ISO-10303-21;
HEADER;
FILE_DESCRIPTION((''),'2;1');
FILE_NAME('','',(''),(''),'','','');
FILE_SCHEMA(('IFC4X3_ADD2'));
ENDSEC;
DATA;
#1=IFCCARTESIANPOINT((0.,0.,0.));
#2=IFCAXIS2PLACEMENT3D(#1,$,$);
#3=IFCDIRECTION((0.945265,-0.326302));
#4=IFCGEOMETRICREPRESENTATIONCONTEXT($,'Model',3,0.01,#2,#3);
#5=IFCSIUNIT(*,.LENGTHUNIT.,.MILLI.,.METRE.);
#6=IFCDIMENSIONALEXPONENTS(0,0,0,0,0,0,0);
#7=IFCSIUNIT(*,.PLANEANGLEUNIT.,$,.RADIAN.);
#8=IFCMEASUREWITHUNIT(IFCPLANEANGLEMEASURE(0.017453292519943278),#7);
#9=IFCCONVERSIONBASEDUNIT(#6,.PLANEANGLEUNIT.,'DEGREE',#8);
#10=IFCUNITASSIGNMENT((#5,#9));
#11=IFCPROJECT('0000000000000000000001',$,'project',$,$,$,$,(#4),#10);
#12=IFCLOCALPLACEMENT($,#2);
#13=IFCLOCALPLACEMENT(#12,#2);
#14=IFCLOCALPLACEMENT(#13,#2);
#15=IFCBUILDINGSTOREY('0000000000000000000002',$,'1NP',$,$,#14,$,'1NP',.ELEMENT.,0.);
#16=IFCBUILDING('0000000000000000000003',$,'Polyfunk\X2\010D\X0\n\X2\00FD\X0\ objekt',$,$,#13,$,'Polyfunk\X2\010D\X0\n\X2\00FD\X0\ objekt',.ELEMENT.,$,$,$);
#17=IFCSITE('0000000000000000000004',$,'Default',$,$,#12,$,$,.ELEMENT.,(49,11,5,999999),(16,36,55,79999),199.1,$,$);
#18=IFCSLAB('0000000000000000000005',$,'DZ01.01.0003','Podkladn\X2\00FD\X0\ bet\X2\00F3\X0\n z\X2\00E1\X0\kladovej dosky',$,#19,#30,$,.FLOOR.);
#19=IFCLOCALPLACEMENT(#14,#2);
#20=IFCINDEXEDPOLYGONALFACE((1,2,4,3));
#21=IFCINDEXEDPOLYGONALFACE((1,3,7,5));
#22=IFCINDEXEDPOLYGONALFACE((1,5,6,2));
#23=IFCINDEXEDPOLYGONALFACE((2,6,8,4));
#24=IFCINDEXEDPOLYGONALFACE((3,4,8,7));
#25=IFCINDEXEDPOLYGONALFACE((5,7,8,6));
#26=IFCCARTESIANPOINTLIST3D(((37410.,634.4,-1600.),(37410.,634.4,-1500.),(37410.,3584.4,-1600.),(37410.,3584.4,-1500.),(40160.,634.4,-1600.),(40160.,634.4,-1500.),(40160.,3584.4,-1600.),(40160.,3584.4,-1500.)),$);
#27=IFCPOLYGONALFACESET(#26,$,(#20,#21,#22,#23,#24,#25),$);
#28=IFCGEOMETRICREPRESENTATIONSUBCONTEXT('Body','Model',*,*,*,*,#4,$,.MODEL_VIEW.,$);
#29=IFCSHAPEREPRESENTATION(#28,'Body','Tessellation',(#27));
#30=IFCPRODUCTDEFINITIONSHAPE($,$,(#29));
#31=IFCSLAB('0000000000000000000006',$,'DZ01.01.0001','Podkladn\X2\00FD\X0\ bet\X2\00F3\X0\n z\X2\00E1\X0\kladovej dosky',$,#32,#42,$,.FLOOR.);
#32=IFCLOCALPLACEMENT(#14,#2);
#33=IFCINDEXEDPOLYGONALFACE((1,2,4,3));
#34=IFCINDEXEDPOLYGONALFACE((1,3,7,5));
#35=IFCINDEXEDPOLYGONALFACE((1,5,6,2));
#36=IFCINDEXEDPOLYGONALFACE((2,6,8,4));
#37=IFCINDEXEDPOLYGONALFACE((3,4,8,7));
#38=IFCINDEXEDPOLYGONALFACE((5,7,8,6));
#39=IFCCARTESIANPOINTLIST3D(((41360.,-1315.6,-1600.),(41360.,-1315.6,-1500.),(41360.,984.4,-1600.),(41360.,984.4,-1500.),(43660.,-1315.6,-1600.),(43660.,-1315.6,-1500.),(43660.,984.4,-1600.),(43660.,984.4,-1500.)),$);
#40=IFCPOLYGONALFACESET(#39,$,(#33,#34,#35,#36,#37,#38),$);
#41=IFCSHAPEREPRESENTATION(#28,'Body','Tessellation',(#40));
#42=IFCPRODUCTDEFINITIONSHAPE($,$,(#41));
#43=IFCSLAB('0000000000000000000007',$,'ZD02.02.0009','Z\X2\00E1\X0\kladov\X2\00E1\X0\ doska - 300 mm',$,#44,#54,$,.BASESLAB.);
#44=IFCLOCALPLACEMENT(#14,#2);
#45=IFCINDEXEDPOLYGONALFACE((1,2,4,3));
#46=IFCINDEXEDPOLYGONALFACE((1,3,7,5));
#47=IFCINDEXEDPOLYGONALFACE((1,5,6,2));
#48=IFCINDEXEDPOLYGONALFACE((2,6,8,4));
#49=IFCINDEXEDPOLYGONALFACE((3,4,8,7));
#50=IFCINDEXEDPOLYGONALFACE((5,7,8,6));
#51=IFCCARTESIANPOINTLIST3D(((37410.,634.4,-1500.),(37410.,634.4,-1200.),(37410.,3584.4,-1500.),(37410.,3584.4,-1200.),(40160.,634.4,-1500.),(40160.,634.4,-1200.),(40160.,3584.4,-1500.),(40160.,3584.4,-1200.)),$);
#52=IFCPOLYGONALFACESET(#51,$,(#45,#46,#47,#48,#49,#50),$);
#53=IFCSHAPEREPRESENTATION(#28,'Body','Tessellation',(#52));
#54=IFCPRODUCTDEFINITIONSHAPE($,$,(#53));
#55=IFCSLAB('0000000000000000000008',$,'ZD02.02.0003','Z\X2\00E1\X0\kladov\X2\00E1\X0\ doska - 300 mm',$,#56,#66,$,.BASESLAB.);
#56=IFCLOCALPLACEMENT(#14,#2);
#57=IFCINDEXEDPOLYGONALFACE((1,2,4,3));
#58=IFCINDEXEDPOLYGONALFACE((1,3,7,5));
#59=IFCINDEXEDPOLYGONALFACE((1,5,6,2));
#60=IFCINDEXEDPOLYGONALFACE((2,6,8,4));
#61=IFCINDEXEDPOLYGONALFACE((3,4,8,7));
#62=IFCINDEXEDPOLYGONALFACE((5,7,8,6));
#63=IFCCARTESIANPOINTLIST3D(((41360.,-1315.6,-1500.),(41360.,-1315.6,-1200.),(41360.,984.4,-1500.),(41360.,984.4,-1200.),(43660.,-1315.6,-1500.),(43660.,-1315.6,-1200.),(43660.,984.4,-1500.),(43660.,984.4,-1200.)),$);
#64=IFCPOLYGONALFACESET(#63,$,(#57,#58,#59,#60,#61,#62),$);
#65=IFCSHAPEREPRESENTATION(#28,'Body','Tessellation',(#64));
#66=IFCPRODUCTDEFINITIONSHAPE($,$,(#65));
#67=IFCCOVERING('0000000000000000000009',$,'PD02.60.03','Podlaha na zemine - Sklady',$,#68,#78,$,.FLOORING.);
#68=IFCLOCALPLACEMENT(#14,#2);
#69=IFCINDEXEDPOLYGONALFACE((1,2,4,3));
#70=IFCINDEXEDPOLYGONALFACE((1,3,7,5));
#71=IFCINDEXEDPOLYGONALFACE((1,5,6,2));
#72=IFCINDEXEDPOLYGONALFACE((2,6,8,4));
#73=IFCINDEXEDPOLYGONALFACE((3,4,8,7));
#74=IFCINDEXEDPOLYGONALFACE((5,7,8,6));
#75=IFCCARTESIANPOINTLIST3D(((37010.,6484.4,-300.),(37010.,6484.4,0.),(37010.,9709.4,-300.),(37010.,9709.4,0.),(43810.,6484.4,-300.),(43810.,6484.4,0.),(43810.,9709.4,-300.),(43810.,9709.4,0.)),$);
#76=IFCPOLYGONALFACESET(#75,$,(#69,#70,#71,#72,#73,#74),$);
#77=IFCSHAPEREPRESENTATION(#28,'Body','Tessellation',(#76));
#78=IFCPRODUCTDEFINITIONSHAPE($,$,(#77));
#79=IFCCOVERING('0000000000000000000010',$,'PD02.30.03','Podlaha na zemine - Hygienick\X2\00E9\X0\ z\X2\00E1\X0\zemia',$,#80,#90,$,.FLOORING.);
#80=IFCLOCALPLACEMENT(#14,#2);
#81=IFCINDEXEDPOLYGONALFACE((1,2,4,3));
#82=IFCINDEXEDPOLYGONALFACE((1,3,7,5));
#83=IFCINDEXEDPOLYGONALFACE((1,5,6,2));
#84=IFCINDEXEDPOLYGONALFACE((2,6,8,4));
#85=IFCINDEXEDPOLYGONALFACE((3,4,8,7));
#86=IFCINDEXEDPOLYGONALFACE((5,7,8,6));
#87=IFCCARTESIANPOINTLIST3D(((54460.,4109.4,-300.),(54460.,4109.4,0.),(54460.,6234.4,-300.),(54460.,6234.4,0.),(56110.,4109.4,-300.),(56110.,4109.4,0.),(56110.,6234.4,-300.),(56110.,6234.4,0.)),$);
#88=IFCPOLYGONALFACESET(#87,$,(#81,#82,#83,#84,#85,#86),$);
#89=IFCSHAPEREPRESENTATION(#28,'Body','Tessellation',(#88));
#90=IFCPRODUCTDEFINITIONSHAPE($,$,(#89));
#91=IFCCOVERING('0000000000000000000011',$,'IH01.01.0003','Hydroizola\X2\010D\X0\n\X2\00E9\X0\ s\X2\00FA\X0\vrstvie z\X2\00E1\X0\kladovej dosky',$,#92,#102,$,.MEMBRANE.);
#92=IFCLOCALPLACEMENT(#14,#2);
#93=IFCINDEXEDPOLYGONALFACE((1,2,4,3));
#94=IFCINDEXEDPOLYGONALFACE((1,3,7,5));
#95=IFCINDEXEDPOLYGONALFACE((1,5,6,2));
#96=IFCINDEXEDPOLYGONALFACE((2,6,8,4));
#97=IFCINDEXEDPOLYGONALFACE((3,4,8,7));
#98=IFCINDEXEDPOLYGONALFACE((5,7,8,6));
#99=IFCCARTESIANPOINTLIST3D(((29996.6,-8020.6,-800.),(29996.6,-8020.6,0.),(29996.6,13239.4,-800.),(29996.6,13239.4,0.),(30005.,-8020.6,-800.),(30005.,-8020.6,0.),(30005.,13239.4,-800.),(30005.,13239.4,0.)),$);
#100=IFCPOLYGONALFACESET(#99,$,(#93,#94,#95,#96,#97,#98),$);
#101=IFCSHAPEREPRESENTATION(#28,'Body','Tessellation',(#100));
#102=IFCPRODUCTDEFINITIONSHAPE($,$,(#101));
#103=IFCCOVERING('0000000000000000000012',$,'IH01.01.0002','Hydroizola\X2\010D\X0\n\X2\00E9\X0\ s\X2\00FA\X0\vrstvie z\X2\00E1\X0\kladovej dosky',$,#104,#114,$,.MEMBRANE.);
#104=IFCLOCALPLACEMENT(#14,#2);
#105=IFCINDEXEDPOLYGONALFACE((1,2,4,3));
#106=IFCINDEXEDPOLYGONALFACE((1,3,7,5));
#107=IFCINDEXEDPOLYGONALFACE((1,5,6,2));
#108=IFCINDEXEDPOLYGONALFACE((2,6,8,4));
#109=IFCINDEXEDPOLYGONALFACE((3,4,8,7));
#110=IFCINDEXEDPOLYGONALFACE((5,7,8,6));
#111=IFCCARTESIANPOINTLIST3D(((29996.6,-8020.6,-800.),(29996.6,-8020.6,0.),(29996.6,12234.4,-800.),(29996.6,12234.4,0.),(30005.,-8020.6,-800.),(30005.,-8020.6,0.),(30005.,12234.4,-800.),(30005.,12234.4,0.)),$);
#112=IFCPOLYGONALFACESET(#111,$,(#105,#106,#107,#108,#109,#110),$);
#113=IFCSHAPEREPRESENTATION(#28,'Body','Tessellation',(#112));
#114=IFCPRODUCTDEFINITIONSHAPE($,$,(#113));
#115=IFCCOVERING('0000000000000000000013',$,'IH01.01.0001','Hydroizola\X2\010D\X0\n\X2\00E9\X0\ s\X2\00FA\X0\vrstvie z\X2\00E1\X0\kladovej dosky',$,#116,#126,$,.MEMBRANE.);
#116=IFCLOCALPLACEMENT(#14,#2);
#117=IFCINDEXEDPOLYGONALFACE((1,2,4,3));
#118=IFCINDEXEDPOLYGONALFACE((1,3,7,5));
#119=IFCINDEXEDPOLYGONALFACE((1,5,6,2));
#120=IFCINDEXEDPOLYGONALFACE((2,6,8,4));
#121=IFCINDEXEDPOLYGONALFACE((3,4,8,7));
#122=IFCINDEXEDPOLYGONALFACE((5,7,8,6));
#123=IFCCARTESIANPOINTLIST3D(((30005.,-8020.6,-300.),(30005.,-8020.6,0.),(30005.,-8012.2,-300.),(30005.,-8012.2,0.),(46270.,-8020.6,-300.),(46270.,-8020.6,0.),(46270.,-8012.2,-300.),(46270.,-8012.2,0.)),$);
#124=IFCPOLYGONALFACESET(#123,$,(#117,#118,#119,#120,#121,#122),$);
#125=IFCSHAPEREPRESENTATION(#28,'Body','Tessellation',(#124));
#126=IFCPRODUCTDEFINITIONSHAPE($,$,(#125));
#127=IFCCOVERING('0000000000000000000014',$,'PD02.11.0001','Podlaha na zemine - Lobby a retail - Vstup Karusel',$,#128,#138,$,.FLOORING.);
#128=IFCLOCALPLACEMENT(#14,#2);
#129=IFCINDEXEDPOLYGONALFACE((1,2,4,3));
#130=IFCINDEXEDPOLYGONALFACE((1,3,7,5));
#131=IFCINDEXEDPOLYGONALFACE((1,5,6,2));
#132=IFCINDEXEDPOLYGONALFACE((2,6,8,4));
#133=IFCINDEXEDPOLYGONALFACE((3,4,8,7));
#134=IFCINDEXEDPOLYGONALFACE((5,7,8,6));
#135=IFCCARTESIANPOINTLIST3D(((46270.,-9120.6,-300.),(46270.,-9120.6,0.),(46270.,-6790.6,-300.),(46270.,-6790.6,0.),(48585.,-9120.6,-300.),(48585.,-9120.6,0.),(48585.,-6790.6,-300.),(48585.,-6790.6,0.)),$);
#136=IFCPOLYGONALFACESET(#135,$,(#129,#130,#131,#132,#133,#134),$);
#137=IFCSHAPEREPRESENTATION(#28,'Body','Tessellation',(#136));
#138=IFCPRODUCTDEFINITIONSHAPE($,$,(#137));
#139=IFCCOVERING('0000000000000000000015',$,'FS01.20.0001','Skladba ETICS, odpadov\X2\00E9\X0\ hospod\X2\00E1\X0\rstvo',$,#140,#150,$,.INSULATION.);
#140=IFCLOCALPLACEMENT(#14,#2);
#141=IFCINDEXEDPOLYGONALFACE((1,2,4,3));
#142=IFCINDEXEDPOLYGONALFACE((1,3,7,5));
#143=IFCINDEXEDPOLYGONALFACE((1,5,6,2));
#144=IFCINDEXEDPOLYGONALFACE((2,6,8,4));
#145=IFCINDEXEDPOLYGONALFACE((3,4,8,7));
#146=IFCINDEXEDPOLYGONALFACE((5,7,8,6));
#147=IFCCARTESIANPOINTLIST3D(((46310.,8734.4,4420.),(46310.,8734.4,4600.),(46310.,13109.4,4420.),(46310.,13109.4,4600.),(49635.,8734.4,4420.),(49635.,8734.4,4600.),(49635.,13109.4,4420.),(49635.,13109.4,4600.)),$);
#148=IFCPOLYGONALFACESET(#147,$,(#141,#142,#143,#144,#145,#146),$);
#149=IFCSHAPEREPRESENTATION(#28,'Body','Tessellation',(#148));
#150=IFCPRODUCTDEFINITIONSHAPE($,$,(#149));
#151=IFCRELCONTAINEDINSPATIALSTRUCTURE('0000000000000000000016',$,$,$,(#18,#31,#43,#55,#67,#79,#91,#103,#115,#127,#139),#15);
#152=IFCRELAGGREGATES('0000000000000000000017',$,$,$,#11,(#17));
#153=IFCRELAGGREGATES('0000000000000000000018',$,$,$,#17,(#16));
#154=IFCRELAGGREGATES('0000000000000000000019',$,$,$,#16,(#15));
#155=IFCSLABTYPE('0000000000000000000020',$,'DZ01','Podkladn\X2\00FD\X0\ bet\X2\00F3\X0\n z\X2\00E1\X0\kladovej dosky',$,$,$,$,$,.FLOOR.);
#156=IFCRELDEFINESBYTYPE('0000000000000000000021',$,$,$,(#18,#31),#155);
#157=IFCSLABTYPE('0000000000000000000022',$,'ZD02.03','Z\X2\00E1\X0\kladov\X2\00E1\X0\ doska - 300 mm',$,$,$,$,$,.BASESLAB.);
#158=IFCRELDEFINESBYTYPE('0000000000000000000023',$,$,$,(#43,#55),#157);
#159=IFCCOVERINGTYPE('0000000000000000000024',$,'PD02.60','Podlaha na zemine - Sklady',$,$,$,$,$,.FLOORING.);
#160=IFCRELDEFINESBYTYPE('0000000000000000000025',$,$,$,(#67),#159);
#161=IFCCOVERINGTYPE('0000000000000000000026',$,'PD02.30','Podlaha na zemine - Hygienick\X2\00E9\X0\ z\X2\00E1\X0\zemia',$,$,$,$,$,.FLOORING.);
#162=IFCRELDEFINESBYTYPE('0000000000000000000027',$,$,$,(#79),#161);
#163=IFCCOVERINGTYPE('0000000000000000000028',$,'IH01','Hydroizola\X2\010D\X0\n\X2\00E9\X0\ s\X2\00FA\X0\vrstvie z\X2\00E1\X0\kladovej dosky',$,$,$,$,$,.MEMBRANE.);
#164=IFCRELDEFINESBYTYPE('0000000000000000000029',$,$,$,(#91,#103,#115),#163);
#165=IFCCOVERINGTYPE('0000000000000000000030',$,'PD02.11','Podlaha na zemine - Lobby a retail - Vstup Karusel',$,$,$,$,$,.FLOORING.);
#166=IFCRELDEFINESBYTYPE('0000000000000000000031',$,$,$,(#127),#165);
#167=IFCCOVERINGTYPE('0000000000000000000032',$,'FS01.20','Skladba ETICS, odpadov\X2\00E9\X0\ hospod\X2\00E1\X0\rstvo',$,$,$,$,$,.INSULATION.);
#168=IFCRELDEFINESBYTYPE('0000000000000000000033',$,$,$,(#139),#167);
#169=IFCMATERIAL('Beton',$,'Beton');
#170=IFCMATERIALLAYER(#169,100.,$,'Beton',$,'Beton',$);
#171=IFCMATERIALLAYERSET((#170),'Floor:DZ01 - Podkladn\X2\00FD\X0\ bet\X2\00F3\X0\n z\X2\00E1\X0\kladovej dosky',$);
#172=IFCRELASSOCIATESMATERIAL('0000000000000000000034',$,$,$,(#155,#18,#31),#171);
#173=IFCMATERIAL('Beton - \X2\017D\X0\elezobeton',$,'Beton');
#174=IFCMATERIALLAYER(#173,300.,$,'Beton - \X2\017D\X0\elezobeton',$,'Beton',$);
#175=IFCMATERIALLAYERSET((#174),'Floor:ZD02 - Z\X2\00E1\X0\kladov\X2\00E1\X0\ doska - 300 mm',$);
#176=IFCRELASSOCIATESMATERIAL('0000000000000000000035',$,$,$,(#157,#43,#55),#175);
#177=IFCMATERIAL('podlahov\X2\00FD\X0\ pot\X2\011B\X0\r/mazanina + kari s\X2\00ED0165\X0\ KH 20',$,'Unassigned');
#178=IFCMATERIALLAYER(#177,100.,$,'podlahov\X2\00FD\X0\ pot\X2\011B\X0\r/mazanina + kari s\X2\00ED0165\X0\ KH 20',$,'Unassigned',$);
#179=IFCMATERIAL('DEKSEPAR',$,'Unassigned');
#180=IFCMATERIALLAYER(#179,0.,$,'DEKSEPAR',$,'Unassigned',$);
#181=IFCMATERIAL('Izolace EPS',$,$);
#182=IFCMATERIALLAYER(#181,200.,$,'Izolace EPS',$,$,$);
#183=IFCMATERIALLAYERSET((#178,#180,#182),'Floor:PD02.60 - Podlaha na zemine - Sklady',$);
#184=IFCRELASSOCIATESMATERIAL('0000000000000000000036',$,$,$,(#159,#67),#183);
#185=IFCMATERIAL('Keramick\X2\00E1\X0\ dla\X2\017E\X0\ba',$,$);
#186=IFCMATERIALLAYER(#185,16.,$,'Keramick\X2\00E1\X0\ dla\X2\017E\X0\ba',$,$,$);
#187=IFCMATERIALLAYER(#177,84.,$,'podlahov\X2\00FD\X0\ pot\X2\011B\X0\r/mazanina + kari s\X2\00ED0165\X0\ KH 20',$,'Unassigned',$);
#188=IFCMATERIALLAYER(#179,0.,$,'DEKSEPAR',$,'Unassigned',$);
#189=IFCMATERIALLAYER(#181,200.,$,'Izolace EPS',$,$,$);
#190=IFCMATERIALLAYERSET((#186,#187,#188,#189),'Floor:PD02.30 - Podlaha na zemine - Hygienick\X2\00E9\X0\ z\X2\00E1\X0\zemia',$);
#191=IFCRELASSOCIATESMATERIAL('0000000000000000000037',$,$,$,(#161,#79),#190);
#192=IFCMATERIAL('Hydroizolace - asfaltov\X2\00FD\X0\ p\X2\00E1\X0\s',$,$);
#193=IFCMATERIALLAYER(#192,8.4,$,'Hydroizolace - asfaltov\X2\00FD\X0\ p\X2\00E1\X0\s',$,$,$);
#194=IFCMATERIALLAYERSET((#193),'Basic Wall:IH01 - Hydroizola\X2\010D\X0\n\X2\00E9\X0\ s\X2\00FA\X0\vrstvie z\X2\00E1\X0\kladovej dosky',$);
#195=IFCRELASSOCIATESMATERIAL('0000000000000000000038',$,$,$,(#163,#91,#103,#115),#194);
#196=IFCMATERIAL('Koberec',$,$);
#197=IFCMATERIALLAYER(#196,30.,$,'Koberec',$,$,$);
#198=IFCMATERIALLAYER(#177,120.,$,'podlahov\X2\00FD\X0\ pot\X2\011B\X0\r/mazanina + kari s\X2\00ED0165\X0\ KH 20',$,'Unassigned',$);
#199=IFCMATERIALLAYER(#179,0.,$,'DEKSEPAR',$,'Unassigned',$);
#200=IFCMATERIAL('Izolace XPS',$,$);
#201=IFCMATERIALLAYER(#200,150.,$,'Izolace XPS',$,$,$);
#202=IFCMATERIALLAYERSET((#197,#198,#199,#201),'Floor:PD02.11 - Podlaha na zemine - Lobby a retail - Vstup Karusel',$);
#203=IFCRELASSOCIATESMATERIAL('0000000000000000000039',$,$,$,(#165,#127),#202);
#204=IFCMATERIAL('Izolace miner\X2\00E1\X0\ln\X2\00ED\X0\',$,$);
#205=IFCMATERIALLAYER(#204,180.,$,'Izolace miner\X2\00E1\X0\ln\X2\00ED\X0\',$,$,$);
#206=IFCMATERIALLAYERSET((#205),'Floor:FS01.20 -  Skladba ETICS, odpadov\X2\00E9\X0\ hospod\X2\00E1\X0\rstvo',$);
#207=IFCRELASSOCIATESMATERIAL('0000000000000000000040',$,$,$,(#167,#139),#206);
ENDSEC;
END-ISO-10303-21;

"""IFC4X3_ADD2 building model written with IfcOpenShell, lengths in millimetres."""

from ifc_helpers import new_model, entity, si_unit, converted_unit, direction, frame, frame_2d, origin, origin_2d_with_axis, place, context, subcontext, project, spatial, rectangle, extrude, material, layer, layer_set, layer_usage, type_object, element, save


model = new_model("IFC4X3_ADD2")

# Units and contexts
model_context = context("Model", 3, precision=0.01, world=origin(), true_north=direction((0.945265, -0.326302)))
body_context = subcontext(model_context, "Body", "Model", "MODEL_VIEW")
ifc_project = project(units=[si_unit("LENGTHUNIT", "METRE", prefix="MILLI"), converted_unit("PLANEANGLEUNIT", "DEGREE", entity("IfcPlaneAngleMeasure", 0.017453292519943278), si_unit("PLANEANGLEUNIT", "RADIAN"), dimensions=[0, 0, 0, 0, 0, 0, 0])], contexts=[model_context])

# Site, building, storey
site_placement = place(None, origin())
site = spatial("IfcSite", under=ifc_project, at=site_placement, Name="Default", CompositionType="ELEMENT", RefLatitude=(49, 11, 5, 999999), RefLongitude=(16, 36, 55, 79999), RefElevation=199.1)
building_placement = place(site_placement, origin())
building = spatial("IfcBuilding", under=site, at=building_placement, Name="Polyfunkčný objekt", LongName="Polyfunkčný objekt", CompositionType="ELEMENT")
storey_placement = place(building_placement, origin())
storey = spatial("IfcBuildingStorey", under=building, at=storey_placement, Name="1NP", LongName="1NP", CompositionType="ELEMENT", Elevation=0.0)

# Shared definitions
ifc_material_1 = material(Name="Beton", Category="Beton")
ifc_layer_1 = layer(ifc_material_1, 100.0, Name="Beton", Category="Beton")
ifc_layer_set_1 = layer_set([ifc_layer_1], Name="Floor:DZ01 - Podkladný betón základovej dosky")
slab_type_1 = type_object("IfcSlabType", Name="DZ01", Description="Podkladný betón základovej dosky", PredefinedType="FLOOR", material=ifc_layer_set_1)

# Slabs
ifc_layer_usage_1 = layer_usage(ifc_layer_set_1, "AXIS3", "POSITIVE", 0.0)
slab_1_placement = place(storey_placement, origin())
element("IfcSlab", 1, at=slab_1_placement, inside=storey, type_object=slab_type_1, material=ifc_layer_usage_1, Name="DZ01.01.0003", Description="Podkladný betón základovej dosky", PredefinedType="FLOOR", context=body_context, shape_type="SweptSolid", body=[
    extrude(rectangle(XDim=2950.0, YDim=2750.0, at=frame_2d((0.0, 0.0), x_axis=(1.0, 0.0))), frame((38785.0, 2109.4, -1500.0), z_axis=(0.0, 0.0, -1.0), x_axis=(0.0, 1.0, 0.0)), (0.0, 0.0, 1.0), 100.0),
])
ifc_layer_usage_2 = layer_usage(ifc_layer_set_1, "AXIS3", "POSITIVE", 0.0)
slab_2_placement = place(storey_placement, origin())
element("IfcSlab", 2, at=slab_2_placement, inside=storey, type_object=slab_type_1, material=ifc_layer_usage_2, Name="DZ01.01.0001", Description="Podkladný betón základovej dosky", PredefinedType="FLOOR", context=body_context, shape_type="SweptSolid", body=[
    extrude(rectangle(XDim=2300.0, YDim=2300.0, at=frame_2d((0.0, 0.0), x_axis=(1.0, 0.0))), frame((42510.0, -165.6, -1500.0), z_axis=(0.0, 0.0, -1.0), x_axis=(0.0, 1.0, 0.0)), (0.0, 0.0, 1.0), 100.0),
])
ifc_material_2 = material(Name="Beton - Železobeton", Category="Beton")
ifc_layer_2 = layer(ifc_material_2, 300.0, Name="Beton - Železobeton", Category="Beton")
ifc_layer_set_2 = layer_set([ifc_layer_2], Name="Floor:ZD02 - Základová doska - 300 mm")
ifc_layer_usage_3 = layer_usage(ifc_layer_set_2, "AXIS3", "POSITIVE", 0.0)
slab_type_2 = type_object("IfcSlabType", Name="ZD02.03", Description="Základová doska - 300 mm", PredefinedType="BASESLAB", material=ifc_layer_set_2)
slab_3_placement = place(storey_placement, origin())
element("IfcSlab", 3, at=slab_3_placement, inside=storey, type_object=slab_type_2, material=ifc_layer_usage_3, Name="ZD02.02.0009", Description="Základová doska - 300 mm", PredefinedType="BASESLAB", context=body_context, shape_type="SweptSolid", body=[
    extrude(rectangle(XDim=2950.0, YDim=2750.0, at=frame_2d((0.0, 0.0), x_axis=(1.0, 0.0))), frame((38785.0, 2109.4, -1200.0), z_axis=(0.0, 0.0, -1.0), x_axis=(0.0, 1.0, 0.0)), (0.0, 0.0, 1.0), 300.0),
])
ifc_layer_usage_4 = layer_usage(ifc_layer_set_2, "AXIS3", "POSITIVE", 0.0)
slab_4_placement = place(storey_placement, origin())
element("IfcSlab", 4, at=slab_4_placement, inside=storey, type_object=slab_type_2, material=ifc_layer_usage_4, Name="ZD02.02.0003", Description="Základová doska - 300 mm", PredefinedType="BASESLAB", context=body_context, shape_type="SweptSolid", body=[
    extrude(rectangle(XDim=2300.0, YDim=2300.0, at=frame_2d((0.0, 0.0), x_axis=(1.0, 0.0))), frame((42510.0, -165.6, -1200.0), z_axis=(0.0, 0.0, -1.0), x_axis=(0.0, 1.0, 0.0)), (0.0, 0.0, 1.0), 300.0),
])

# Coverings
ifc_material_3 = material(Name="podlahový potěr/mazanina + kari síť KH 20", Category="Unassigned")
ifc_layer_3 = layer(ifc_material_3, 100.0, Name="podlahový potěr/mazanina + kari síť KH 20", Category="Unassigned")
ifc_material_4 = material(Name="DEKSEPAR", Category="Unassigned")
ifc_layer_4 = layer(ifc_material_4, 0.0, Name="DEKSEPAR", Category="Unassigned")
ifc_material_5 = material(Name="Izolace EPS")
ifc_layer_5 = layer(ifc_material_5, 200.0, Name="Izolace EPS")
ifc_layer_set_3 = layer_set([ifc_layer_3, ifc_layer_4, ifc_layer_5], Name="Floor:PD02.60 - Podlaha na zemine - Sklady")
ifc_layer_usage_5 = layer_usage(ifc_layer_set_3, "AXIS3", "POSITIVE", 0.0)
covering_type_1 = type_object("IfcCoveringType", Name="PD02.60", Description="Podlaha na zemine - Sklady", PredefinedType="FLOORING", material=ifc_layer_set_3)
covering_1_placement = place(storey_placement, origin())
element("IfcCovering", 5, at=covering_1_placement, inside=storey, type_object=covering_type_1, material=ifc_layer_usage_5, Name="PD02.60.03", Description="Podlaha na zemine - Sklady", PredefinedType="FLOORING", context=body_context, shape_type="SweptSolid", body=[
    extrude(rectangle(XDim=3225.0, YDim=6800.0, at=origin_2d_with_axis()), frame((40410.0, 8096.9, 0.0), z_axis=(0.0, 0.0, -1.0), x_axis=(0.0, 1.0, 0.0)), (0.0, 0.0, 1.0), 300.0),
])
ifc_material_6 = material(Name="Keramická dlažba")
ifc_layer_6 = layer(ifc_material_6, 16.0, Name="Keramická dlažba")
ifc_layer_7 = layer(ifc_material_3, 84.0, Name="podlahový potěr/mazanina + kari síť KH 20", Category="Unassigned")
ifc_layer_8 = layer(ifc_material_4, 0.0, Name="DEKSEPAR", Category="Unassigned")
ifc_layer_9 = layer(ifc_material_5, 200.0, Name="Izolace EPS")
ifc_layer_set_4 = layer_set([ifc_layer_6, ifc_layer_7, ifc_layer_8, ifc_layer_9], Name="Floor:PD02.30 - Podlaha na zemine - Hygienické zázemia")
covering_type_2 = type_object("IfcCoveringType", Name="PD02.30", Description="Podlaha na zemine - Hygienické zázemia", PredefinedType="FLOORING", material=ifc_layer_set_4)
ifc_layer_usage_6 = layer_usage(ifc_layer_set_4, "AXIS3", "POSITIVE", 0.0)
covering_2_placement = place(storey_placement, origin())
element("IfcCovering", 6, at=covering_2_placement, inside=storey, type_object=covering_type_2, material=ifc_layer_usage_6, Name="PD02.30.03", Description="Podlaha na zemine - Hygienické zázemia", PredefinedType="FLOORING", context=body_context, shape_type="SweptSolid", body=[
    extrude(rectangle(XDim=2125.0, YDim=1650.0, at=frame_2d((0.0, 0.0), x_axis=(1.0, 0.0))), frame((55285.0, 5171.9, 0.0), z_axis=(0.0, 0.0, -1.0), x_axis=(0.0, 1.0, 0.0)), (0.0, 0.0, 1.0), 300.0),
])
ifc_material_7 = material(Name="Hydroizolace - asfaltový pás")
ifc_layer_10 = layer(ifc_material_7, 8.4, Name="Hydroizolace - asfaltový pás")
ifc_layer_set_5 = layer_set([ifc_layer_10], Name="Basic Wall:IH01 - Hydroizolačné súvrstvie základovej dosky")
covering_type_3 = type_object("IfcCoveringType", Name="IH01", Description="Hydroizolačné súvrstvie základovej dosky", PredefinedType="MEMBRANE", material=ifc_layer_set_5)
covering_3_placement = place(storey_placement, frame((30000.8, -8020.6, -800.0), z_axis=(0.0, 0.0, 1.0), x_axis=(0.0, 1.0, 0.0)))
element("IfcCovering", 7, at=covering_3_placement, inside=storey, type_object=covering_type_3, material=ifc_layer_set_5, Name="IH01.01.0003", Description="Hydroizolačné súvrstvie základovej dosky", PredefinedType="MEMBRANE", context=body_context, shape_type="SweptSolid", body=[
    extrude(rectangle(XDim=21260.0, YDim=8.4, at=frame_2d((10630.0, 0.0), x_axis=(-1.0, 0.0))), origin(), (0.0, 0.0, 1.0), 800.0),
])
covering_4_placement = place(storey_placement, frame((30000.8, -8020.6, -800.0), z_axis=(0.0, 0.0, 1.0), x_axis=(0.0, 1.0, 0.0)))
element("IfcCovering", 8, at=covering_4_placement, inside=storey, type_object=covering_type_3, material=ifc_layer_set_5, Name="IH01.01.0002", Description="Hydroizolačné súvrstvie základovej dosky", PredefinedType="MEMBRANE", context=body_context, shape_type="SweptSolid", body=[
    extrude(rectangle(XDim=20255.0, YDim=8.4, at=frame_2d((10127.5, 0.0), x_axis=(-1.0, 0.0))), origin(), (0.0, 0.0, 1.0), 800.0),
])
covering_5_placement = place(storey_placement, frame((30005.0, -8016.4, -300.0)))
element("IfcCovering", 9, at=covering_5_placement, inside=storey, type_object=covering_type_3, material=ifc_layer_set_5, Name="IH01.01.0001", Description="Hydroizolačné súvrstvie základovej dosky", PredefinedType="MEMBRANE", context=body_context, shape_type="SweptSolid", body=[
    extrude(rectangle(XDim=16265.0, YDim=8.4, at=frame_2d((8132.5, 0.0), x_axis=(-1.0, 0.0))), origin(), (0.0, 0.0, 1.0), 300.0),
])
ifc_material_8 = material(Name="Koberec")
ifc_layer_11 = layer(ifc_material_8, 30.0, Name="Koberec")
ifc_layer_12 = layer(ifc_material_3, 120.0, Name="podlahový potěr/mazanina + kari síť KH 20", Category="Unassigned")
ifc_layer_13 = layer(ifc_material_4, 0.0, Name="DEKSEPAR", Category="Unassigned")
ifc_material_9 = material(Name="Izolace XPS")
ifc_layer_14 = layer(ifc_material_9, 150.0, Name="Izolace XPS")
ifc_layer_set_6 = layer_set([ifc_layer_11, ifc_layer_12, ifc_layer_13, ifc_layer_14], Name="Floor:PD02.11 - Podlaha na zemine - Lobby a retail - Vstup Karusel")
ifc_layer_usage_7 = layer_usage(ifc_layer_set_6, "AXIS3", "POSITIVE", 0.0)
covering_type_4 = type_object("IfcCoveringType", Name="PD02.11", Description="Podlaha na zemine - Lobby a retail - Vstup Karusel", PredefinedType="FLOORING", material=ifc_layer_set_6)
covering_6_placement = place(storey_placement, origin())
element("IfcCovering", 10, at=covering_6_placement, inside=storey, type_object=covering_type_4, material=ifc_layer_usage_7, Name="PD02.11.0001", Description="Podlaha na zemine - Lobby a retail - Vstup Karusel", PredefinedType="FLOORING", context=body_context, shape_type="SweptSolid", body=[
    extrude(rectangle(XDim=2330.0, YDim=2315.0, at=frame_2d((0.0, 0.0), x_axis=(1.0, 0.0))), frame((47427.5, -7955.6, 0.0), z_axis=(0.0, 0.0, -1.0), x_axis=(0.0, 1.0, 0.0)), (0.0, 0.0, 1.0), 300.0),
])
ifc_material_10 = material(Name="Izolace minerální")
ifc_layer_15 = layer(ifc_material_10, 180.0, Name="Izolace minerální")
ifc_layer_set_7 = layer_set([ifc_layer_15], Name="Floor:FS01.20 -  Skladba ETICS, odpadové hospodárstvo")
ifc_layer_usage_8 = layer_usage(ifc_layer_set_7, "AXIS3", "POSITIVE", 0.0)
covering_type_5 = type_object("IfcCoveringType", Name="FS01.20", Description="Skladba ETICS, odpadové hospodárstvo", PredefinedType="INSULATION", material=ifc_layer_set_7)
covering_7_placement = place(storey_placement, origin())
element("IfcCovering", 11, at=covering_7_placement, inside=storey, type_object=covering_type_5, material=ifc_layer_usage_8, Name="FS01.20.0001", Description="Skladba ETICS, odpadové hospodárstvo", PredefinedType="INSULATION", context=body_context, shape_type="SweptSolid", body=[
    extrude(rectangle(XDim=4375.0, YDim=3325.0, at=frame_2d((0.0, 0.0), x_axis=(1.0, 0.0))), frame((47972.5, 10921.9, 4600.0), z_axis=(0.0, 0.0, -1.0), x_axis=(0.0, 1.0, 0.0)), (0.0, 0.0, 1.0), 180.0),
])

save(model, "model.ifc")
